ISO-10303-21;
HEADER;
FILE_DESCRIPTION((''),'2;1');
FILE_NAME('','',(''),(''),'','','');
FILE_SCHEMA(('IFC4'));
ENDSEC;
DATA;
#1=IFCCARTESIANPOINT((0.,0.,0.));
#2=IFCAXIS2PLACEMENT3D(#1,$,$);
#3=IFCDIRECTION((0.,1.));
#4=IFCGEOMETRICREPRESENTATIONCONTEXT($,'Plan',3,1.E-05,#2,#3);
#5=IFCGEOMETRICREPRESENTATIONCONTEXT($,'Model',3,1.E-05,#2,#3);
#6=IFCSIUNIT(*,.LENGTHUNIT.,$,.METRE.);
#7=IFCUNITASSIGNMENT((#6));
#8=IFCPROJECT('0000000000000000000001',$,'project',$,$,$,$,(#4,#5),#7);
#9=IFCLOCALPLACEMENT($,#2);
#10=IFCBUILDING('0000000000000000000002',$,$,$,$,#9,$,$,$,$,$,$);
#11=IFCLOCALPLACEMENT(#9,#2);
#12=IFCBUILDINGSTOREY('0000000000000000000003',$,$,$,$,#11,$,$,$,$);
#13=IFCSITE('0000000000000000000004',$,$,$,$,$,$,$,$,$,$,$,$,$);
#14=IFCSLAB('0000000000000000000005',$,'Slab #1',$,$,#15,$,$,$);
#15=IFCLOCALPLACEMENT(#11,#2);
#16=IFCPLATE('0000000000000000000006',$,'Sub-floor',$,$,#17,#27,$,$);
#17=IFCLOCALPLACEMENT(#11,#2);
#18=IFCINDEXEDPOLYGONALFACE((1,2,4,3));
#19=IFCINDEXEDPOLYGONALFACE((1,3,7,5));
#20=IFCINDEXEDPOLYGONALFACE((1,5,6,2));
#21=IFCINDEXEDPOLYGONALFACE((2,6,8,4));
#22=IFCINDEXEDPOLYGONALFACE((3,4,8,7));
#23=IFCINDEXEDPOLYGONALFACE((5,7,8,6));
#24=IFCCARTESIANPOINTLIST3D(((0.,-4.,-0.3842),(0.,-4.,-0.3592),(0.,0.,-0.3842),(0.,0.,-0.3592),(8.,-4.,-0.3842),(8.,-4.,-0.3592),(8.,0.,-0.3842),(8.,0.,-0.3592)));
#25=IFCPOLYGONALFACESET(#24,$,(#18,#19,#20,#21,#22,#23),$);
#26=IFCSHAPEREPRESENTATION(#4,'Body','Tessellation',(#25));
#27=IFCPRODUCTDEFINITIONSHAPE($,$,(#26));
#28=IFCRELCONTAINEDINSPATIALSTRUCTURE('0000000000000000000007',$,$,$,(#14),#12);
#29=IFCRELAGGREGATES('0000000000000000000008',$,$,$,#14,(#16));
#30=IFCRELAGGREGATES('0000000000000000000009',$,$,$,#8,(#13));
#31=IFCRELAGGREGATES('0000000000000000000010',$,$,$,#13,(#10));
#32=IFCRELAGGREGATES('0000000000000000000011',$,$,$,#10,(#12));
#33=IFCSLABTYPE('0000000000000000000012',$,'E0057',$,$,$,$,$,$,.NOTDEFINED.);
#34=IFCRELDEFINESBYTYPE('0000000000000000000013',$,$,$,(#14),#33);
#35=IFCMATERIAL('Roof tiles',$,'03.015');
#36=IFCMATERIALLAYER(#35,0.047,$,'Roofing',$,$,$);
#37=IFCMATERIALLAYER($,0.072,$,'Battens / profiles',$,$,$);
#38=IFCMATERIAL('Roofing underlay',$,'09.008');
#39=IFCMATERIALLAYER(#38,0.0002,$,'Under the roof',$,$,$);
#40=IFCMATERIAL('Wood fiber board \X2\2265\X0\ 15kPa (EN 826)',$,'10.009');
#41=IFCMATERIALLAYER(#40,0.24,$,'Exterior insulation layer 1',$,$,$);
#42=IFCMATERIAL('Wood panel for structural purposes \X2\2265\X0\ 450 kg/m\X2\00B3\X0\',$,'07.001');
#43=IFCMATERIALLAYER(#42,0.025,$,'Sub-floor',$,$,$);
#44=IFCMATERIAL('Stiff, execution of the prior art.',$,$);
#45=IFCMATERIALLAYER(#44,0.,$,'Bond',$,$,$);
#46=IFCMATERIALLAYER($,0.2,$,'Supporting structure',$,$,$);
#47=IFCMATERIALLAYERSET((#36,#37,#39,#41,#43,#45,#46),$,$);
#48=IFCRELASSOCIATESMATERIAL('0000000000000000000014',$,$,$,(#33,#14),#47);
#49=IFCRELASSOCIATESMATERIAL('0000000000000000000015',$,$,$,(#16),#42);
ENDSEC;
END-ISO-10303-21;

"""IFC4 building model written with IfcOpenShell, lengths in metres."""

from ifc_helpers import new_model, si_unit, direction, frame, frame_2d, origin, place, context, project, spatial, rectangle, extrude, material, layer, layer_set, type_object, element, aggregate, save


model = new_model("IFC4")

# Units and contexts
plan_context = context("Plan", 3, precision=1e-05, world=origin(), true_north=direction((0.0, 1.0)))
model_context = context("Model", 3, precision=1e-05, world=origin(), true_north=direction((0.0, 1.0)))
ifc_project = project(units=[si_unit("LENGTHUNIT", "METRE")], contexts=[plan_context, model_context])

# Site, building, storey
site = spatial("IfcSite", under=ifc_project)
building_placement = place(None, origin())
building = spatial("IfcBuilding", under=site, at=building_placement)
storey_placement = place(building_placement, origin())
storey = spatial("IfcBuildingStorey", under=building, at=storey_placement)

# Slab, plate
ifc_material_1 = material(Name="Roof tiles", Category="03.015")
ifc_layer_1 = layer(ifc_material_1, 0.047, Name="Roofing")
ifc_layer_2 = layer(None, 0.072, Name="Battens / profiles")
ifc_material_2 = material(Name="Roofing underlay", Category="09.008")
ifc_layer_3 = layer(ifc_material_2, 0.0002, Name="Under the roof")
ifc_material_3 = material(Name="Wood fiber board ≥ 15kPa (EN 826)", Category="10.009")
ifc_layer_4 = layer(ifc_material_3, 0.24, Name="Exterior insulation layer 1")
ifc_material_4 = material(Name="Wood panel for structural purposes ≥ 450 kg/m³", Category="07.001")
ifc_layer_5 = layer(ifc_material_4, 0.025, Name="Sub-floor")
ifc_material_5 = material(Name="Stiff, execution of the prior art.")
ifc_layer_6 = layer(ifc_material_5, 0.0, Name="Bond")
ifc_layer_7 = layer(None, 0.2, Name="Supporting structure")
ifc_layer_set = layer_set([ifc_layer_1, ifc_layer_2, ifc_layer_3, ifc_layer_4, ifc_layer_5, ifc_layer_6, ifc_layer_7])
slab_type = type_object("IfcSlabType", Name="E0057", PredefinedType="NOTDEFINED", material=ifc_layer_set)
slab_placement = place(None, frame((0.0, 0.0, 0.0), z_axis=(0.0, 0.0, -1.0), x_axis=(1.0, 0.0, 0.0)))
slab = element("IfcSlab", 1, at=slab_placement, inside=storey, type_object=slab_type, material=ifc_layer_set, Name="Slab #1")
plate_1_placement = place(slab_placement, origin())
plate_1 = element("IfcPlate", 2, at=plate_1_placement, material=ifc_material_4, Name="Sub-floor", context=plan_context, shape_type="SweptSolid", body=[
    extrude(rectangle(XDim=8.0, YDim=4.0, at=frame_2d((4.0, 2.0), x_axis=(1.0, 0.0))), frame((0.0, 0.0, 0.3592), z_axis=(0.0, 0.0, 1.0), x_axis=(1.0, 0.0, 0.0)), (0.0, 0.0, 1.0), 0.025),
])
aggregate(slab, [plate_1])

save(model, "model.ifc")
